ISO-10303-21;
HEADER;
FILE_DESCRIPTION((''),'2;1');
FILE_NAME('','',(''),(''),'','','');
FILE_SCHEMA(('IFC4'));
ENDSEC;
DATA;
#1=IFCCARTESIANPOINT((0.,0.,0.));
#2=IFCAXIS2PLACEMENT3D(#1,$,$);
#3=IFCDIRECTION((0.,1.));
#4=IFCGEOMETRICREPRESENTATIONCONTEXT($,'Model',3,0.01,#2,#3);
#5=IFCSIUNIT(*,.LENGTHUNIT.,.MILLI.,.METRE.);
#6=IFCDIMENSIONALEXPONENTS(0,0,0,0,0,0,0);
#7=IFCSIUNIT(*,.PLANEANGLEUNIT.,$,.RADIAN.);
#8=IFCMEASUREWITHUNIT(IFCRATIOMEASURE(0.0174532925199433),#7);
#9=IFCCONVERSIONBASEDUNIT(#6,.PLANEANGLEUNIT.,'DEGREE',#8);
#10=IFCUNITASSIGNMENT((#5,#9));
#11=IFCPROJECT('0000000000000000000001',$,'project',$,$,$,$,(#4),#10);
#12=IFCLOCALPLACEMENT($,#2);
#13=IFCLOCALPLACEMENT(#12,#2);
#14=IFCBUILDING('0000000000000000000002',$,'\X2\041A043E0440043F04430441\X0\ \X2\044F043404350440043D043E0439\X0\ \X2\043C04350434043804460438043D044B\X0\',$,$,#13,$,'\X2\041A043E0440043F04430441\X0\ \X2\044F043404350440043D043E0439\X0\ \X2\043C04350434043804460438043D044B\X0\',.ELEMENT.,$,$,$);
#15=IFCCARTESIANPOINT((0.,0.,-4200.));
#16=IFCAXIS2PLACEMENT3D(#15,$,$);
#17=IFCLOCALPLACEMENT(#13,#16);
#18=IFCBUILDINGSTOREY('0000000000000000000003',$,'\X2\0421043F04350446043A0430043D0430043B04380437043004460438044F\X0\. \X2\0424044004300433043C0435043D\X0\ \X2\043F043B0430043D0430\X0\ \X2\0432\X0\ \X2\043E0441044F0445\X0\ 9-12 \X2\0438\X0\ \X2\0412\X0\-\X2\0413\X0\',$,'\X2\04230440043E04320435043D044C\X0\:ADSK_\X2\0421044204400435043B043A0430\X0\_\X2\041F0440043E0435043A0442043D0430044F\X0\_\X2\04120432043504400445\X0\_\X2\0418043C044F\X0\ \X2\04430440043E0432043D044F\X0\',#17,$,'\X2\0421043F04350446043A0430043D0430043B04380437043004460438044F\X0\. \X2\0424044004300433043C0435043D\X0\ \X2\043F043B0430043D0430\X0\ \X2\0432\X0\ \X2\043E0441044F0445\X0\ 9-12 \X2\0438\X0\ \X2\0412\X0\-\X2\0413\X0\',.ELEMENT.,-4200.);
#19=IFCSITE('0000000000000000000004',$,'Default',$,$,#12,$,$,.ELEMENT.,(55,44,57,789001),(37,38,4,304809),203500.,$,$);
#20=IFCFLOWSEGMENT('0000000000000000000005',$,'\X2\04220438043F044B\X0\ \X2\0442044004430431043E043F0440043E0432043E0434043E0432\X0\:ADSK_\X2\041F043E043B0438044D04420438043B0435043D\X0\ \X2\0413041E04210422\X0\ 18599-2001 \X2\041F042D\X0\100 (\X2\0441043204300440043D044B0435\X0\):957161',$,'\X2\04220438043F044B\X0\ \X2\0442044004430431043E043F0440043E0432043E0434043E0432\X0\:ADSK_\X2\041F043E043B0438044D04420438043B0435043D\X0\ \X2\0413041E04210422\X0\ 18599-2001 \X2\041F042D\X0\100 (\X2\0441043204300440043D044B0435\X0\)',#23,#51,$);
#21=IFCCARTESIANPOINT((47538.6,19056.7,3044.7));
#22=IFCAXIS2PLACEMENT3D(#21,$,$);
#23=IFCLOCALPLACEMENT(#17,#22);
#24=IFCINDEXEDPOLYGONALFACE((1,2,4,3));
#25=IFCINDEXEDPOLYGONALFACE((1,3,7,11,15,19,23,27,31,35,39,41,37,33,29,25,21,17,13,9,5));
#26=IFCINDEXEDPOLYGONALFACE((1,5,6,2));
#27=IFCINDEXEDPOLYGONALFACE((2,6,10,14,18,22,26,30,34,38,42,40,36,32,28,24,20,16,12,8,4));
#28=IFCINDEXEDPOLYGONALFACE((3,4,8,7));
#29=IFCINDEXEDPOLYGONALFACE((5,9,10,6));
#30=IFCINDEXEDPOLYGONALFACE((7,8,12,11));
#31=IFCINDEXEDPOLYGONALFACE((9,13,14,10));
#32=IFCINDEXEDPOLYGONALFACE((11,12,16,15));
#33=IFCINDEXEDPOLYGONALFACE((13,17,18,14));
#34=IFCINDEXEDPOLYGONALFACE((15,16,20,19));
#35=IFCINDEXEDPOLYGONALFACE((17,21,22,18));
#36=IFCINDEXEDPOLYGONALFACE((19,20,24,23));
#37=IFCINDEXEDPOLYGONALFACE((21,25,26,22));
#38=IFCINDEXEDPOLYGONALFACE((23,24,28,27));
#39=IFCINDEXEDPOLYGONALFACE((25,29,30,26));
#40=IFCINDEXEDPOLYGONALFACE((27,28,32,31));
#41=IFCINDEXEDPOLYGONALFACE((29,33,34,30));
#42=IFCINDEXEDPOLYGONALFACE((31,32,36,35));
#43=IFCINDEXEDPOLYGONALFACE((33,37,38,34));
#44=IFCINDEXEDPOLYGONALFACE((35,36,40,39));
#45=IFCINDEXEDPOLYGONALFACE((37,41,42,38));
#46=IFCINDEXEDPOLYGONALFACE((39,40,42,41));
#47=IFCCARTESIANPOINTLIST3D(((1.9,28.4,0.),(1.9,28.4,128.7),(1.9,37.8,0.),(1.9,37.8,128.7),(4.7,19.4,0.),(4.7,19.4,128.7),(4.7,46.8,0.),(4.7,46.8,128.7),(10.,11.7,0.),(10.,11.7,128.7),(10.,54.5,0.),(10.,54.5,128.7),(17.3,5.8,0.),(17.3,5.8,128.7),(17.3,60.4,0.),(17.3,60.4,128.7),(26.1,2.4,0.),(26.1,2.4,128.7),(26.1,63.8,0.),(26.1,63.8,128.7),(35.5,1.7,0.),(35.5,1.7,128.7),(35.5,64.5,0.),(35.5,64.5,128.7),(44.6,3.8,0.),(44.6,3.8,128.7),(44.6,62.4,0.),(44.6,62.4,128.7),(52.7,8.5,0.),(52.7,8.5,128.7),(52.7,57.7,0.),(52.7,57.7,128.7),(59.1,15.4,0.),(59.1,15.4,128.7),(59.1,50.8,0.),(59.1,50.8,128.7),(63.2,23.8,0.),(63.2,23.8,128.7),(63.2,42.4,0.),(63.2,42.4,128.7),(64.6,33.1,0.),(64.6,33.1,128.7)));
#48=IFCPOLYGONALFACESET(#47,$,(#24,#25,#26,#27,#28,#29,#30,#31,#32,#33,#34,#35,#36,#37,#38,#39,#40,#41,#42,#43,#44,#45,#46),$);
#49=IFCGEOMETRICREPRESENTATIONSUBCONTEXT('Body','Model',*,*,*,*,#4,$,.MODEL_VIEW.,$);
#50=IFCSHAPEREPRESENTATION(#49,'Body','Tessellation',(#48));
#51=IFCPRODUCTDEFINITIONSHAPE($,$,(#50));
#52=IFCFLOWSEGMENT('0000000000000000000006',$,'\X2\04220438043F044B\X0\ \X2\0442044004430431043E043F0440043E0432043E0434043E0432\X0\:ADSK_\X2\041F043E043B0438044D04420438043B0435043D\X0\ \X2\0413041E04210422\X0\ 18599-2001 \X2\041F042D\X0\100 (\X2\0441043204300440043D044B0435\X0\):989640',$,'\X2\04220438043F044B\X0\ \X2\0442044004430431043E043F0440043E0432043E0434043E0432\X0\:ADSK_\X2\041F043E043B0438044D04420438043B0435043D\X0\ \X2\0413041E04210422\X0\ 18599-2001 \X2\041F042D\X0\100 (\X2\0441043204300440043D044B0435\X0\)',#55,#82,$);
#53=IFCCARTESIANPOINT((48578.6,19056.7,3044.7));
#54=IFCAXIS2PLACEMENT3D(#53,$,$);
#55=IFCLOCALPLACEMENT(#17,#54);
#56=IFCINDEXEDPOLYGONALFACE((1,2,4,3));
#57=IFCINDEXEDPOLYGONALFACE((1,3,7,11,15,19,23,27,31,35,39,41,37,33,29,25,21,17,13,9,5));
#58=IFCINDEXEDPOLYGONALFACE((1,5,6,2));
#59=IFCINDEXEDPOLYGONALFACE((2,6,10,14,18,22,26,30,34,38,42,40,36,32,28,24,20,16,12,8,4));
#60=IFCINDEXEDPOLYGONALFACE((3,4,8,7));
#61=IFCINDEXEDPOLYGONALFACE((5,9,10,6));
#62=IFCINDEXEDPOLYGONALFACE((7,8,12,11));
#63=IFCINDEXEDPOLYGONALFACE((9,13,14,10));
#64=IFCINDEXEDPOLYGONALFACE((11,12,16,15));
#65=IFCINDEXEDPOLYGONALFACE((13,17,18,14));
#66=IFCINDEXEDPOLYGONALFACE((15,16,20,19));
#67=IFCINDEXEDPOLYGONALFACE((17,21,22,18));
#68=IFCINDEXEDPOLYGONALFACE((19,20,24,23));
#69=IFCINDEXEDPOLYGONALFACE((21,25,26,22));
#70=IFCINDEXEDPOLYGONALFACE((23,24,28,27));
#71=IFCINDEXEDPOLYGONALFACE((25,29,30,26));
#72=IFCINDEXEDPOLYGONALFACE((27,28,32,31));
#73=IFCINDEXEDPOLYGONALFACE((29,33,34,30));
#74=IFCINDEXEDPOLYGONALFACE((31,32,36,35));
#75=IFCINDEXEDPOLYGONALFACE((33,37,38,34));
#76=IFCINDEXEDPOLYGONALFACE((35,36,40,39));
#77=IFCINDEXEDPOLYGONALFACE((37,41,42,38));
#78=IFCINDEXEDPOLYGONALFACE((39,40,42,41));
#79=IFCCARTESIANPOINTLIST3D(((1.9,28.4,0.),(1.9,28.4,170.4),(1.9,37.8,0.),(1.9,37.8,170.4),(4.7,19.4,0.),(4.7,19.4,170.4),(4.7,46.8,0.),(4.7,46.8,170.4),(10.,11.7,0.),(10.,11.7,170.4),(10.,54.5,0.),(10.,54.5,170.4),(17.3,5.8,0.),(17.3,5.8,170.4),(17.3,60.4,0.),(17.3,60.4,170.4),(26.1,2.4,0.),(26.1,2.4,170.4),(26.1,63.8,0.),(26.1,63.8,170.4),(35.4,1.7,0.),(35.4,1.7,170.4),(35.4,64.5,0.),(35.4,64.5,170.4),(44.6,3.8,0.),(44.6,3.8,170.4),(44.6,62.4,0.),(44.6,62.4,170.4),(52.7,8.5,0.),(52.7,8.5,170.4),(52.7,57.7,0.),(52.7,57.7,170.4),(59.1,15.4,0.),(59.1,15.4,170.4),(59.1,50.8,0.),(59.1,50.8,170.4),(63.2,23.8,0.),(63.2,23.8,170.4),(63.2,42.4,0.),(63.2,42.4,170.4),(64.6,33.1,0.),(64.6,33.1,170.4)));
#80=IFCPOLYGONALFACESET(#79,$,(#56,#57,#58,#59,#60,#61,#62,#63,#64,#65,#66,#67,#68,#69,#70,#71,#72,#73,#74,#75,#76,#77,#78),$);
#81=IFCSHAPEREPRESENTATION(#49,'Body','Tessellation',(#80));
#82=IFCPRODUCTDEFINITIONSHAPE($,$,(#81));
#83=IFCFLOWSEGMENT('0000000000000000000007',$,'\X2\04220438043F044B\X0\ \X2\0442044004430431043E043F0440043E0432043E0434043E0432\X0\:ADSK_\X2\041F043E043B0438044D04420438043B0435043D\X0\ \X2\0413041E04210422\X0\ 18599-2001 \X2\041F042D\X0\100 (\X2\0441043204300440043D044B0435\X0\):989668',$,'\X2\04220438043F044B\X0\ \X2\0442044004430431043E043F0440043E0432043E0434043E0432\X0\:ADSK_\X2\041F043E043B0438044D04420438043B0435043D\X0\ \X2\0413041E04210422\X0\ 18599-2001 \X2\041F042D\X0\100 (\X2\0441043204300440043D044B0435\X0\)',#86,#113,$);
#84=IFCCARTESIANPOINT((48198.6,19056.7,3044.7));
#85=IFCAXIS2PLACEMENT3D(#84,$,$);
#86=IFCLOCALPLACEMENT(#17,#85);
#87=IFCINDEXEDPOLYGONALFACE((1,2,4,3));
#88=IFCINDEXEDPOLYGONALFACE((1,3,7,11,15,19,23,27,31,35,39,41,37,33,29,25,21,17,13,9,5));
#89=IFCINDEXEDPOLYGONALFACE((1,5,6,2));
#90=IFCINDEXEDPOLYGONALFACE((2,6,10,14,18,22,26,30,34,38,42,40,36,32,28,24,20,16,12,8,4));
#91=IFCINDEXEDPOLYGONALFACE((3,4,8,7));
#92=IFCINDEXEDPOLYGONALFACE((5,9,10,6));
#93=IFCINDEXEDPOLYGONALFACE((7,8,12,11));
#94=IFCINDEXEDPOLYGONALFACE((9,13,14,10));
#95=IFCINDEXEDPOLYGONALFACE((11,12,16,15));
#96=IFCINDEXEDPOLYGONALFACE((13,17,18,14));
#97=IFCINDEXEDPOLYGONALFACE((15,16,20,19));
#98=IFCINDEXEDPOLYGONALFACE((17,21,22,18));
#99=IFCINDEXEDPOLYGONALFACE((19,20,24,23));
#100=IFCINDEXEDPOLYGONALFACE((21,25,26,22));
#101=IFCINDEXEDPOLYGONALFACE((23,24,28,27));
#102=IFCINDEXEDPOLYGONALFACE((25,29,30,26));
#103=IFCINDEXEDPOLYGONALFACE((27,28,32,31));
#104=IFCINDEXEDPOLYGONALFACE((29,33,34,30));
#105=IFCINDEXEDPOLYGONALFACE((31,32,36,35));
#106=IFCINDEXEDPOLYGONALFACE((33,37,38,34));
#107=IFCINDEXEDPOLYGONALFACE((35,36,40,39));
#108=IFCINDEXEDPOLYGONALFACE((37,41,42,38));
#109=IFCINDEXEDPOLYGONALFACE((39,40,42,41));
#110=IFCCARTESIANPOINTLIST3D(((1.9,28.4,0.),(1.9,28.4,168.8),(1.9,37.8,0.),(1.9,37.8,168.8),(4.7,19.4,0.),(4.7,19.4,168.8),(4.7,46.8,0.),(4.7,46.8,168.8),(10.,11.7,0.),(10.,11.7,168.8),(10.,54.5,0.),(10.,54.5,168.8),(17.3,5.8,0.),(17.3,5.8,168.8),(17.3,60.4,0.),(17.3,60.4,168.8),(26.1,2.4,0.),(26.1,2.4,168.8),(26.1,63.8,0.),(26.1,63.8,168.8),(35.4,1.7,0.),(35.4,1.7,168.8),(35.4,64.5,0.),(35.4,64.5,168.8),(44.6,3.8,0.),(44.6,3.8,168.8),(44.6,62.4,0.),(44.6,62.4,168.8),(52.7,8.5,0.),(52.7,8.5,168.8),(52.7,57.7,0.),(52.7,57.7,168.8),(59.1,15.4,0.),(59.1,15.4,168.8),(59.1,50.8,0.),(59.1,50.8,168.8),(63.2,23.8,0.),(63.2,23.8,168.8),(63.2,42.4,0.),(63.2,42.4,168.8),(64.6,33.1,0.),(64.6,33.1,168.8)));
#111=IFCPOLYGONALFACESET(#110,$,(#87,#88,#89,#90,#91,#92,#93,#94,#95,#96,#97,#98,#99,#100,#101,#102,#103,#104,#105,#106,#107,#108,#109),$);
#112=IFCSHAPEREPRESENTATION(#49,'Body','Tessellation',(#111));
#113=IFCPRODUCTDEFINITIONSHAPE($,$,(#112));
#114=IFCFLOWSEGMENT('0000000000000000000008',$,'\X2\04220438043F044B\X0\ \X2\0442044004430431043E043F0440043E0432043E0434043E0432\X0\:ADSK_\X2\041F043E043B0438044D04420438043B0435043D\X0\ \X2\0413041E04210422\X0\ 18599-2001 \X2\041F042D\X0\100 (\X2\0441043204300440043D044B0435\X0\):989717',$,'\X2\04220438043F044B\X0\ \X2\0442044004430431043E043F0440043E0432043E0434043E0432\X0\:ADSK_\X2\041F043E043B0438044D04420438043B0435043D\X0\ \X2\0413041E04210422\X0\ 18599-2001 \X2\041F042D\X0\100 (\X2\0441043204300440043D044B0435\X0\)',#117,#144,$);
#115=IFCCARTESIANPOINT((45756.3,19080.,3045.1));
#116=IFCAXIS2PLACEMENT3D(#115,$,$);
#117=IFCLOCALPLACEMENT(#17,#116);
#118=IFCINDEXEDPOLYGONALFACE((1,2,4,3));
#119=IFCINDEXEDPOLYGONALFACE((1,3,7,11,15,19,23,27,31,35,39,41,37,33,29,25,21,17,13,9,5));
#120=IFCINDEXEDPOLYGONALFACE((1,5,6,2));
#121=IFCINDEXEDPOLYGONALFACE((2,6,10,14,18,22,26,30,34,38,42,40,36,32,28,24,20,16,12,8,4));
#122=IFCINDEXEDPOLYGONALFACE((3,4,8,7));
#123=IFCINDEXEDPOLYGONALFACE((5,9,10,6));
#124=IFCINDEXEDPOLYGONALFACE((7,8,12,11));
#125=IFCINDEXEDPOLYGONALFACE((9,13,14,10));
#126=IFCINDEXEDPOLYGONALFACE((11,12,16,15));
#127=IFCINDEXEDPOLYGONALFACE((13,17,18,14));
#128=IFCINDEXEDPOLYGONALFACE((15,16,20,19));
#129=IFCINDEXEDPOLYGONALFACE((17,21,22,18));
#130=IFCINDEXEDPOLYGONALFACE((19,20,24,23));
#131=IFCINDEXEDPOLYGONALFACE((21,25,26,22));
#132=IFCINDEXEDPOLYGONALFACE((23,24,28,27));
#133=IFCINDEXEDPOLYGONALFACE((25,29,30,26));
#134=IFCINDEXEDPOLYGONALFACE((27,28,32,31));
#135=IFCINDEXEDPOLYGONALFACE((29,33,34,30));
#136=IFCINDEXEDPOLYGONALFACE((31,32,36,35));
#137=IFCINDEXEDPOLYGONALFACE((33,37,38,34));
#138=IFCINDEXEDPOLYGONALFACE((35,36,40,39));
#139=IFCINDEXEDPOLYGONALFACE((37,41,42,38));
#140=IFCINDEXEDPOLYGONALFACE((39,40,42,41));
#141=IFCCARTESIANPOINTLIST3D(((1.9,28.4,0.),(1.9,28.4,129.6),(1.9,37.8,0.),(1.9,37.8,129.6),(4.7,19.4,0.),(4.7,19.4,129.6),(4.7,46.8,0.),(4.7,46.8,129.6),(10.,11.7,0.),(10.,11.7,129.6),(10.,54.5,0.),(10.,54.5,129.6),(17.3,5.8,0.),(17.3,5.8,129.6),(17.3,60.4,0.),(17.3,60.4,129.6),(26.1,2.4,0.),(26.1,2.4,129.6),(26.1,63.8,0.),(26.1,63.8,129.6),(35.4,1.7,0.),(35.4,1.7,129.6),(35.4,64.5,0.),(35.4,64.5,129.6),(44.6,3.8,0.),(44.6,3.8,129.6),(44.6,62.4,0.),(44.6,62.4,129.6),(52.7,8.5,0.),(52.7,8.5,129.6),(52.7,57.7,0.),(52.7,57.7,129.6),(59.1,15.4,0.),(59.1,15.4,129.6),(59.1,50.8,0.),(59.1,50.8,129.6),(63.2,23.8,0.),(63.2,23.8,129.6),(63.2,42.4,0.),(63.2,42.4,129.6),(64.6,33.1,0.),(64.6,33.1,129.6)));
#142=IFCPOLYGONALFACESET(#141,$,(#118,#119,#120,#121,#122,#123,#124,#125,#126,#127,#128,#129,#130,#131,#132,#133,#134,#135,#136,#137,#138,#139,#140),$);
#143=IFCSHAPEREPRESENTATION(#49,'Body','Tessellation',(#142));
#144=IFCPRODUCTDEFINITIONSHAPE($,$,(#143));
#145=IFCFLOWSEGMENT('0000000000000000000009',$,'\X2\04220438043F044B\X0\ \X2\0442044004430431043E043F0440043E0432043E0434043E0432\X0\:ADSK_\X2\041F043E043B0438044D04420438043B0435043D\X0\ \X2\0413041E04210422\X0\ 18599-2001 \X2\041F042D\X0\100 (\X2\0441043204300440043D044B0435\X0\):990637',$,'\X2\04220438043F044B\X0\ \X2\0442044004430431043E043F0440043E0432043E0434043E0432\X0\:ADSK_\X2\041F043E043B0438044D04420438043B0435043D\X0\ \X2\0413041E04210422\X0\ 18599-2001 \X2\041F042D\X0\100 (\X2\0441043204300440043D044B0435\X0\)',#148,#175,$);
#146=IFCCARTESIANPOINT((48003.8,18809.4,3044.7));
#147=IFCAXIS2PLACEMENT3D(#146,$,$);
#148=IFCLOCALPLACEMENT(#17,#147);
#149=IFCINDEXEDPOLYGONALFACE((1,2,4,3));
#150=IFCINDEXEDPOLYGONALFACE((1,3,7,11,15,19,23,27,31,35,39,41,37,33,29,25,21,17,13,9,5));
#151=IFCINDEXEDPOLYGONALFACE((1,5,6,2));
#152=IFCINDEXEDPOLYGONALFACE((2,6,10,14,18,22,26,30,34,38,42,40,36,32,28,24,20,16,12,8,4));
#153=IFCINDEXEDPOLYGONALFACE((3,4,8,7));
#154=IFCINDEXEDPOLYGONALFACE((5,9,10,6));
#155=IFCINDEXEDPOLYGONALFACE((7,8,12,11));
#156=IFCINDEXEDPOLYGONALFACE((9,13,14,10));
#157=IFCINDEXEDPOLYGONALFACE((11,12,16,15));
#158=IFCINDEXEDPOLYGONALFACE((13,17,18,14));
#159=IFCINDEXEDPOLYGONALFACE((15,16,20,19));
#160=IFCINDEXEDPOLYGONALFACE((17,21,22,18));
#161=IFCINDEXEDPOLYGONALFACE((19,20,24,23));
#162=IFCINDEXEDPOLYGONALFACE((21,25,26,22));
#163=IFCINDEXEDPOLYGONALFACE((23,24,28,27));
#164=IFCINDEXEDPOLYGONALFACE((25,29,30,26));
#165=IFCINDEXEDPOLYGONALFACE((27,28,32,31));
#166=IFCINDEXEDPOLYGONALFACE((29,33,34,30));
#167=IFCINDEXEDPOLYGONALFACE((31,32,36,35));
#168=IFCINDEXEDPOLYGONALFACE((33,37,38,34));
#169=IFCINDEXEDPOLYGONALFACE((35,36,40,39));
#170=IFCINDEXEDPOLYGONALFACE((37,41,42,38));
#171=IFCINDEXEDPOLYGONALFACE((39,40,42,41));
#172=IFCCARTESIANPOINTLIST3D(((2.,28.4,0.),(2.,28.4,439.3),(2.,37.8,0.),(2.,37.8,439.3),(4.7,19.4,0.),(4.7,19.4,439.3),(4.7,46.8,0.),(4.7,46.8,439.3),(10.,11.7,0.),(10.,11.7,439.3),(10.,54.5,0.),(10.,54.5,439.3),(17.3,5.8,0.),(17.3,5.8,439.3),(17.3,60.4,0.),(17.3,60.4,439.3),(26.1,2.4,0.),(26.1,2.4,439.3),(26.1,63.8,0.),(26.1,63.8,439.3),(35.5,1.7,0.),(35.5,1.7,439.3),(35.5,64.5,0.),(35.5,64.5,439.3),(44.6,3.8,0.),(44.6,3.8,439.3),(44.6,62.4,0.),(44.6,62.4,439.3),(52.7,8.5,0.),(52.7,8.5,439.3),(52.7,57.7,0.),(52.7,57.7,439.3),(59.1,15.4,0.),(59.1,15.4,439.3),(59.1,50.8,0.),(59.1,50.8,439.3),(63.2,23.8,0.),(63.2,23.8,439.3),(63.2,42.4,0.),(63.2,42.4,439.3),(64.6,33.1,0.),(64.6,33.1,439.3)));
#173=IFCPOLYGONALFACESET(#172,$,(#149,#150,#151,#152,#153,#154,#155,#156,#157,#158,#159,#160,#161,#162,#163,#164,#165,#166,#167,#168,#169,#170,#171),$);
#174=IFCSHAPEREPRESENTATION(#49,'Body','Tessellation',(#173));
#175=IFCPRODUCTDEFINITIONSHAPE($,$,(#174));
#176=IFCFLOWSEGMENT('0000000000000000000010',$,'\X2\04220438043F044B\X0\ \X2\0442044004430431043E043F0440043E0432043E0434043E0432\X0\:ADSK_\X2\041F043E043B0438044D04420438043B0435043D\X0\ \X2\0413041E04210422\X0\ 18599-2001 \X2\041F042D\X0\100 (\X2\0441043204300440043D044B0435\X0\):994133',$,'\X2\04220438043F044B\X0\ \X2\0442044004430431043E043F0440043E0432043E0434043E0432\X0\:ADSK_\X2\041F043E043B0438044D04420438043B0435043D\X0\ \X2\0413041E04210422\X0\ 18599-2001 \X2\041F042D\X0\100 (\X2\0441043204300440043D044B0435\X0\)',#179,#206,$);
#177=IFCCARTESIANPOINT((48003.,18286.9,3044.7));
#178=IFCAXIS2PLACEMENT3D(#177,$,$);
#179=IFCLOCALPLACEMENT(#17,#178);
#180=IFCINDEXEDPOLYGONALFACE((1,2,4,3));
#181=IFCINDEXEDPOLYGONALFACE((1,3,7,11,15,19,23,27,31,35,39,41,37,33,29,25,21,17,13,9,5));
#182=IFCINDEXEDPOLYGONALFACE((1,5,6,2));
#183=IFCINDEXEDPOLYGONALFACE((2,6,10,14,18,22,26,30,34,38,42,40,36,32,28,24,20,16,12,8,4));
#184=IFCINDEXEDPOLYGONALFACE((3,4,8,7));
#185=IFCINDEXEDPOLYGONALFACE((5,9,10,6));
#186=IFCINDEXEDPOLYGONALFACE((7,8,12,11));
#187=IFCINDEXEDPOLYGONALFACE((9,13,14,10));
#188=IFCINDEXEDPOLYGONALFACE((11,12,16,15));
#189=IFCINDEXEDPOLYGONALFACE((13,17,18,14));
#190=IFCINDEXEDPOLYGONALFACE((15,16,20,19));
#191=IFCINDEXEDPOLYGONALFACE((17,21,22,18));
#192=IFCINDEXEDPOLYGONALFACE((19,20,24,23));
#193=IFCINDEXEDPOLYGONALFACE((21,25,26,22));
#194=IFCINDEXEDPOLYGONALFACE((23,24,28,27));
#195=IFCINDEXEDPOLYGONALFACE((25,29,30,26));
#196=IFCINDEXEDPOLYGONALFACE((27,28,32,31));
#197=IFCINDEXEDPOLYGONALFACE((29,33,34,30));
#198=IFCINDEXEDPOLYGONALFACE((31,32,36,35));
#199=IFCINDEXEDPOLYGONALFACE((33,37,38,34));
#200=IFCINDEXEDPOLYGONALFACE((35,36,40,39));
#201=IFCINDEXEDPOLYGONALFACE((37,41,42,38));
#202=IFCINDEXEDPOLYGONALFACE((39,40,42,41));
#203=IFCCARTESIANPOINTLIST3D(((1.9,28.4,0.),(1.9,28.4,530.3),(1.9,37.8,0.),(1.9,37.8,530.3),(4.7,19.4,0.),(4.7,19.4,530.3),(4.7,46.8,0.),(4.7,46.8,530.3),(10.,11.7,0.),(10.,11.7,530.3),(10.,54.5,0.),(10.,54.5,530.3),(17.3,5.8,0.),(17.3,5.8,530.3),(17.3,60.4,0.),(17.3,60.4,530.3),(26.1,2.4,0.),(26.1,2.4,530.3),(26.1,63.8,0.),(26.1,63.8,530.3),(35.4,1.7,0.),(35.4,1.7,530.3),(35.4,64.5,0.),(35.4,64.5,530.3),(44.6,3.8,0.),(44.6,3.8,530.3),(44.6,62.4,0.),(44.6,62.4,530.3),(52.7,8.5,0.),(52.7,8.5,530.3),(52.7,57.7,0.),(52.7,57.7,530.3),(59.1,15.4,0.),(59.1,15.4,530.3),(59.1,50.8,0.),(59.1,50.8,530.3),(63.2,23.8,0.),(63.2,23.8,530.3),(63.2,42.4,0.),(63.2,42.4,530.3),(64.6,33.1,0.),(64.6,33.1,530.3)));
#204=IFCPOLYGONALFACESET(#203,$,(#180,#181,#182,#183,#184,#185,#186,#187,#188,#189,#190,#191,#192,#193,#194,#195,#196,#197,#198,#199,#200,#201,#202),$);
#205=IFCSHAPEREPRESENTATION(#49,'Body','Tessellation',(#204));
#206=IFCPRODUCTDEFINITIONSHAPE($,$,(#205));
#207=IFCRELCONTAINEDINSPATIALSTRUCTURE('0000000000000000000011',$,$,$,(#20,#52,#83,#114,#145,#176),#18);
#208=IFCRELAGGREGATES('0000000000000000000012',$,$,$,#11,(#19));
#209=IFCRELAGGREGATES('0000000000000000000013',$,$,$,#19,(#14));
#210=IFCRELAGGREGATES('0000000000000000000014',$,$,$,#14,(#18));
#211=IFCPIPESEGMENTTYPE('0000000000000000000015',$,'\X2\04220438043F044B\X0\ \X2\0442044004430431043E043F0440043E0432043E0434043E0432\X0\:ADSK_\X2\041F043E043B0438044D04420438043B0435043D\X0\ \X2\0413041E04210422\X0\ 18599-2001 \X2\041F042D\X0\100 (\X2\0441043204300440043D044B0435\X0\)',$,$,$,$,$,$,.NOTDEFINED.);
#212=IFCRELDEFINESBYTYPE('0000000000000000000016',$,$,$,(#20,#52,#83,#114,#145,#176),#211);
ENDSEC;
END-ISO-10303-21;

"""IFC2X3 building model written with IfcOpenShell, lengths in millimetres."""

from ifc_helpers import new_model, entity, si_unit, converted_unit, direction, frame, frame_2d, origin, origin_2d_with_axis, place, context, subcontext, project, spatial, circle, extrude, type_object, element, save


model = new_model("IFC2X3")

# Units and contexts
model_context = context("Model", 3, precision=0.01, world=origin(), true_north=direction((0.0, 1.0)))
body_context = subcontext(model_context, "Body", "Model", "MODEL_VIEW")
ifc_project = project(units=[si_unit("LENGTHUNIT", "METRE", prefix="MILLI"), converted_unit("PLANEANGLEUNIT", "DEGREE", entity("IfcRatioMeasure", 0.0174532925199433), si_unit("PLANEANGLEUNIT", "RADIAN"), dimensions=[0, 0, 0, 0, 0, 0, 0])], contexts=[model_context])

# Site, building, storey
site_placement = place(None, frame((0.0, 0.0, 0.0)))
site = spatial("IfcSite", under=ifc_project, at=site_placement, Name="Default", CompositionType="ELEMENT", RefLatitude=(55, 44, 57, 789001), RefLongitude=(37, 38, 4, 304809), RefElevation=203500.0)
building_placement = place(site_placement, origin())
building = spatial("IfcBuilding", under=site, at=building_placement, Name="Корпус ядерной медицины", LongName="Корпус ядерной медицины", CompositionType="ELEMENT")
storey_placement = place(building_placement, frame((0.0, 0.0, -4200.0)))
storey = spatial("IfcBuildingStorey", under=building, at=storey_placement, Name="Спецканализация. Фрагмен плана в осях 9-12 и В-Г", ObjectType="Уровень:ADSK_Стрелка_Проектная_Вверх_Имя уровня", LongName="Спецканализация. Фрагмен плана в осях 9-12 и В-Г", CompositionType="ELEMENT", Elevation=-4200.0)

# Flow segments
pipe_segment_type = type_object("IfcPipeSegmentType", Name="Типы трубопроводов:ADSK_Полиэтилен ГОСТ 18599-2001 ПЭ100 (сварные)", PredefinedType="NOTDEFINED")
flow_segment_1_placement = place(storey_placement, frame((47538.6, 19056.7, 3044.7)))
element("IfcFlowSegment", 1, at=flow_segment_1_placement, inside=storey, type_object=pipe_segment_type, Name="Типы трубопроводов:ADSK_Полиэтилен ГОСТ 18599-2001 ПЭ100 (сварные):957161", ObjectType="Типы трубопроводов:ADSK_Полиэтилен ГОСТ 18599-2001 ПЭ100 (сварные)", context=body_context, shape_type="SweptSolid", body=[
    extrude(circle(Radius=31.5, at=origin_2d_with_axis()), frame((33.1, 33.1, 0.0)), (0.0, 0.0, 1.0), 128.7),
])
flow_segment_2_placement = place(storey_placement, frame((48578.6, 19056.7, 3044.7)))
element("IfcFlowSegment", 2, at=flow_segment_2_placement, inside=storey, type_object=pipe_segment_type, Name="Типы трубопроводов:ADSK_Полиэтилен ГОСТ 18599-2001 ПЭ100 (сварные):989640", ObjectType="Типы трубопроводов:ADSK_Полиэтилен ГОСТ 18599-2001 ПЭ100 (сварные)", context=body_context, shape_type="SweptSolid", body=[
    extrude(circle(Radius=31.5, at=origin_2d_with_axis()), frame((33.1, 33.1, 0.0)), (0.0, 0.0, 1.0), 170.4),
])
flow_segment_3_placement = place(storey_placement, frame((48198.6, 19056.7, 3044.7)))
element("IfcFlowSegment", 3, at=flow_segment_3_placement, inside=storey, type_object=pipe_segment_type, Name="Типы трубопроводов:ADSK_Полиэтилен ГОСТ 18599-2001 ПЭ100 (сварные):989668", ObjectType="Типы трубопроводов:ADSK_Полиэтилен ГОСТ 18599-2001 ПЭ100 (сварные)", context=body_context, shape_type="SweptSolid", body=[
    extrude(circle(Radius=31.5, at=frame_2d((0.0, 0.0), x_axis=(1.0, 0.0))), frame((33.1, 33.1, 0.0)), (0.0, 0.0, 1.0), 168.8),
])
flow_segment_4_placement = place(storey_placement, frame((45756.3, 19080.0, 3045.1)))
element("IfcFlowSegment", 4, at=flow_segment_4_placement, inside=storey, type_object=pipe_segment_type, Name="Типы трубопроводов:ADSK_Полиэтилен ГОСТ 18599-2001 ПЭ100 (сварные):989717", ObjectType="Типы трубопроводов:ADSK_Полиэтилен ГОСТ 18599-2001 ПЭ100 (сварные)", context=body_context, shape_type="SweptSolid", body=[
    extrude(circle(Radius=31.5, at=frame_2d((0.0, 0.0), x_axis=(1.0, 0.0))), frame((33.1, 33.1, 0.0)), (0.0, 0.0, 1.0), 129.6),
])
flow_segment_5_placement = place(storey_placement, frame((48003.8, 18809.4, 3044.7)))
element("IfcFlowSegment", 5, at=flow_segment_5_placement, inside=storey, type_object=pipe_segment_type, Name="Типы трубопроводов:ADSK_Полиэтилен ГОСТ 18599-2001 ПЭ100 (сварные):990637", ObjectType="Типы трубопроводов:ADSK_Полиэтилен ГОСТ 18599-2001 ПЭ100 (сварные)", context=body_context, shape_type="SweptSolid", body=[
    extrude(circle(Radius=31.5, at=frame_2d((0.0, 0.0), x_axis=(1.0, 0.0))), frame((33.1, 33.1, 0.0)), (0.0, 0.0, 1.0), 439.3),
])
flow_segment_6_placement = place(storey_placement, frame((48003.0, 18286.9, 3044.7)))
element("IfcFlowSegment", 6, at=flow_segment_6_placement, inside=storey, type_object=pipe_segment_type, Name="Типы трубопроводов:ADSK_Полиэтилен ГОСТ 18599-2001 ПЭ100 (сварные):994133", ObjectType="Типы трубопроводов:ADSK_Полиэтилен ГОСТ 18599-2001 ПЭ100 (сварные)", context=body_context, shape_type="SweptSolid", body=[
    extrude(circle(Radius=31.5, at=frame_2d((0.0, 0.0), x_axis=(1.0, 0.0))), frame((33.1, 33.1, 0.0)), (0.0, 0.0, 1.0), 530.3),
])

save(model, "model.ifc")
